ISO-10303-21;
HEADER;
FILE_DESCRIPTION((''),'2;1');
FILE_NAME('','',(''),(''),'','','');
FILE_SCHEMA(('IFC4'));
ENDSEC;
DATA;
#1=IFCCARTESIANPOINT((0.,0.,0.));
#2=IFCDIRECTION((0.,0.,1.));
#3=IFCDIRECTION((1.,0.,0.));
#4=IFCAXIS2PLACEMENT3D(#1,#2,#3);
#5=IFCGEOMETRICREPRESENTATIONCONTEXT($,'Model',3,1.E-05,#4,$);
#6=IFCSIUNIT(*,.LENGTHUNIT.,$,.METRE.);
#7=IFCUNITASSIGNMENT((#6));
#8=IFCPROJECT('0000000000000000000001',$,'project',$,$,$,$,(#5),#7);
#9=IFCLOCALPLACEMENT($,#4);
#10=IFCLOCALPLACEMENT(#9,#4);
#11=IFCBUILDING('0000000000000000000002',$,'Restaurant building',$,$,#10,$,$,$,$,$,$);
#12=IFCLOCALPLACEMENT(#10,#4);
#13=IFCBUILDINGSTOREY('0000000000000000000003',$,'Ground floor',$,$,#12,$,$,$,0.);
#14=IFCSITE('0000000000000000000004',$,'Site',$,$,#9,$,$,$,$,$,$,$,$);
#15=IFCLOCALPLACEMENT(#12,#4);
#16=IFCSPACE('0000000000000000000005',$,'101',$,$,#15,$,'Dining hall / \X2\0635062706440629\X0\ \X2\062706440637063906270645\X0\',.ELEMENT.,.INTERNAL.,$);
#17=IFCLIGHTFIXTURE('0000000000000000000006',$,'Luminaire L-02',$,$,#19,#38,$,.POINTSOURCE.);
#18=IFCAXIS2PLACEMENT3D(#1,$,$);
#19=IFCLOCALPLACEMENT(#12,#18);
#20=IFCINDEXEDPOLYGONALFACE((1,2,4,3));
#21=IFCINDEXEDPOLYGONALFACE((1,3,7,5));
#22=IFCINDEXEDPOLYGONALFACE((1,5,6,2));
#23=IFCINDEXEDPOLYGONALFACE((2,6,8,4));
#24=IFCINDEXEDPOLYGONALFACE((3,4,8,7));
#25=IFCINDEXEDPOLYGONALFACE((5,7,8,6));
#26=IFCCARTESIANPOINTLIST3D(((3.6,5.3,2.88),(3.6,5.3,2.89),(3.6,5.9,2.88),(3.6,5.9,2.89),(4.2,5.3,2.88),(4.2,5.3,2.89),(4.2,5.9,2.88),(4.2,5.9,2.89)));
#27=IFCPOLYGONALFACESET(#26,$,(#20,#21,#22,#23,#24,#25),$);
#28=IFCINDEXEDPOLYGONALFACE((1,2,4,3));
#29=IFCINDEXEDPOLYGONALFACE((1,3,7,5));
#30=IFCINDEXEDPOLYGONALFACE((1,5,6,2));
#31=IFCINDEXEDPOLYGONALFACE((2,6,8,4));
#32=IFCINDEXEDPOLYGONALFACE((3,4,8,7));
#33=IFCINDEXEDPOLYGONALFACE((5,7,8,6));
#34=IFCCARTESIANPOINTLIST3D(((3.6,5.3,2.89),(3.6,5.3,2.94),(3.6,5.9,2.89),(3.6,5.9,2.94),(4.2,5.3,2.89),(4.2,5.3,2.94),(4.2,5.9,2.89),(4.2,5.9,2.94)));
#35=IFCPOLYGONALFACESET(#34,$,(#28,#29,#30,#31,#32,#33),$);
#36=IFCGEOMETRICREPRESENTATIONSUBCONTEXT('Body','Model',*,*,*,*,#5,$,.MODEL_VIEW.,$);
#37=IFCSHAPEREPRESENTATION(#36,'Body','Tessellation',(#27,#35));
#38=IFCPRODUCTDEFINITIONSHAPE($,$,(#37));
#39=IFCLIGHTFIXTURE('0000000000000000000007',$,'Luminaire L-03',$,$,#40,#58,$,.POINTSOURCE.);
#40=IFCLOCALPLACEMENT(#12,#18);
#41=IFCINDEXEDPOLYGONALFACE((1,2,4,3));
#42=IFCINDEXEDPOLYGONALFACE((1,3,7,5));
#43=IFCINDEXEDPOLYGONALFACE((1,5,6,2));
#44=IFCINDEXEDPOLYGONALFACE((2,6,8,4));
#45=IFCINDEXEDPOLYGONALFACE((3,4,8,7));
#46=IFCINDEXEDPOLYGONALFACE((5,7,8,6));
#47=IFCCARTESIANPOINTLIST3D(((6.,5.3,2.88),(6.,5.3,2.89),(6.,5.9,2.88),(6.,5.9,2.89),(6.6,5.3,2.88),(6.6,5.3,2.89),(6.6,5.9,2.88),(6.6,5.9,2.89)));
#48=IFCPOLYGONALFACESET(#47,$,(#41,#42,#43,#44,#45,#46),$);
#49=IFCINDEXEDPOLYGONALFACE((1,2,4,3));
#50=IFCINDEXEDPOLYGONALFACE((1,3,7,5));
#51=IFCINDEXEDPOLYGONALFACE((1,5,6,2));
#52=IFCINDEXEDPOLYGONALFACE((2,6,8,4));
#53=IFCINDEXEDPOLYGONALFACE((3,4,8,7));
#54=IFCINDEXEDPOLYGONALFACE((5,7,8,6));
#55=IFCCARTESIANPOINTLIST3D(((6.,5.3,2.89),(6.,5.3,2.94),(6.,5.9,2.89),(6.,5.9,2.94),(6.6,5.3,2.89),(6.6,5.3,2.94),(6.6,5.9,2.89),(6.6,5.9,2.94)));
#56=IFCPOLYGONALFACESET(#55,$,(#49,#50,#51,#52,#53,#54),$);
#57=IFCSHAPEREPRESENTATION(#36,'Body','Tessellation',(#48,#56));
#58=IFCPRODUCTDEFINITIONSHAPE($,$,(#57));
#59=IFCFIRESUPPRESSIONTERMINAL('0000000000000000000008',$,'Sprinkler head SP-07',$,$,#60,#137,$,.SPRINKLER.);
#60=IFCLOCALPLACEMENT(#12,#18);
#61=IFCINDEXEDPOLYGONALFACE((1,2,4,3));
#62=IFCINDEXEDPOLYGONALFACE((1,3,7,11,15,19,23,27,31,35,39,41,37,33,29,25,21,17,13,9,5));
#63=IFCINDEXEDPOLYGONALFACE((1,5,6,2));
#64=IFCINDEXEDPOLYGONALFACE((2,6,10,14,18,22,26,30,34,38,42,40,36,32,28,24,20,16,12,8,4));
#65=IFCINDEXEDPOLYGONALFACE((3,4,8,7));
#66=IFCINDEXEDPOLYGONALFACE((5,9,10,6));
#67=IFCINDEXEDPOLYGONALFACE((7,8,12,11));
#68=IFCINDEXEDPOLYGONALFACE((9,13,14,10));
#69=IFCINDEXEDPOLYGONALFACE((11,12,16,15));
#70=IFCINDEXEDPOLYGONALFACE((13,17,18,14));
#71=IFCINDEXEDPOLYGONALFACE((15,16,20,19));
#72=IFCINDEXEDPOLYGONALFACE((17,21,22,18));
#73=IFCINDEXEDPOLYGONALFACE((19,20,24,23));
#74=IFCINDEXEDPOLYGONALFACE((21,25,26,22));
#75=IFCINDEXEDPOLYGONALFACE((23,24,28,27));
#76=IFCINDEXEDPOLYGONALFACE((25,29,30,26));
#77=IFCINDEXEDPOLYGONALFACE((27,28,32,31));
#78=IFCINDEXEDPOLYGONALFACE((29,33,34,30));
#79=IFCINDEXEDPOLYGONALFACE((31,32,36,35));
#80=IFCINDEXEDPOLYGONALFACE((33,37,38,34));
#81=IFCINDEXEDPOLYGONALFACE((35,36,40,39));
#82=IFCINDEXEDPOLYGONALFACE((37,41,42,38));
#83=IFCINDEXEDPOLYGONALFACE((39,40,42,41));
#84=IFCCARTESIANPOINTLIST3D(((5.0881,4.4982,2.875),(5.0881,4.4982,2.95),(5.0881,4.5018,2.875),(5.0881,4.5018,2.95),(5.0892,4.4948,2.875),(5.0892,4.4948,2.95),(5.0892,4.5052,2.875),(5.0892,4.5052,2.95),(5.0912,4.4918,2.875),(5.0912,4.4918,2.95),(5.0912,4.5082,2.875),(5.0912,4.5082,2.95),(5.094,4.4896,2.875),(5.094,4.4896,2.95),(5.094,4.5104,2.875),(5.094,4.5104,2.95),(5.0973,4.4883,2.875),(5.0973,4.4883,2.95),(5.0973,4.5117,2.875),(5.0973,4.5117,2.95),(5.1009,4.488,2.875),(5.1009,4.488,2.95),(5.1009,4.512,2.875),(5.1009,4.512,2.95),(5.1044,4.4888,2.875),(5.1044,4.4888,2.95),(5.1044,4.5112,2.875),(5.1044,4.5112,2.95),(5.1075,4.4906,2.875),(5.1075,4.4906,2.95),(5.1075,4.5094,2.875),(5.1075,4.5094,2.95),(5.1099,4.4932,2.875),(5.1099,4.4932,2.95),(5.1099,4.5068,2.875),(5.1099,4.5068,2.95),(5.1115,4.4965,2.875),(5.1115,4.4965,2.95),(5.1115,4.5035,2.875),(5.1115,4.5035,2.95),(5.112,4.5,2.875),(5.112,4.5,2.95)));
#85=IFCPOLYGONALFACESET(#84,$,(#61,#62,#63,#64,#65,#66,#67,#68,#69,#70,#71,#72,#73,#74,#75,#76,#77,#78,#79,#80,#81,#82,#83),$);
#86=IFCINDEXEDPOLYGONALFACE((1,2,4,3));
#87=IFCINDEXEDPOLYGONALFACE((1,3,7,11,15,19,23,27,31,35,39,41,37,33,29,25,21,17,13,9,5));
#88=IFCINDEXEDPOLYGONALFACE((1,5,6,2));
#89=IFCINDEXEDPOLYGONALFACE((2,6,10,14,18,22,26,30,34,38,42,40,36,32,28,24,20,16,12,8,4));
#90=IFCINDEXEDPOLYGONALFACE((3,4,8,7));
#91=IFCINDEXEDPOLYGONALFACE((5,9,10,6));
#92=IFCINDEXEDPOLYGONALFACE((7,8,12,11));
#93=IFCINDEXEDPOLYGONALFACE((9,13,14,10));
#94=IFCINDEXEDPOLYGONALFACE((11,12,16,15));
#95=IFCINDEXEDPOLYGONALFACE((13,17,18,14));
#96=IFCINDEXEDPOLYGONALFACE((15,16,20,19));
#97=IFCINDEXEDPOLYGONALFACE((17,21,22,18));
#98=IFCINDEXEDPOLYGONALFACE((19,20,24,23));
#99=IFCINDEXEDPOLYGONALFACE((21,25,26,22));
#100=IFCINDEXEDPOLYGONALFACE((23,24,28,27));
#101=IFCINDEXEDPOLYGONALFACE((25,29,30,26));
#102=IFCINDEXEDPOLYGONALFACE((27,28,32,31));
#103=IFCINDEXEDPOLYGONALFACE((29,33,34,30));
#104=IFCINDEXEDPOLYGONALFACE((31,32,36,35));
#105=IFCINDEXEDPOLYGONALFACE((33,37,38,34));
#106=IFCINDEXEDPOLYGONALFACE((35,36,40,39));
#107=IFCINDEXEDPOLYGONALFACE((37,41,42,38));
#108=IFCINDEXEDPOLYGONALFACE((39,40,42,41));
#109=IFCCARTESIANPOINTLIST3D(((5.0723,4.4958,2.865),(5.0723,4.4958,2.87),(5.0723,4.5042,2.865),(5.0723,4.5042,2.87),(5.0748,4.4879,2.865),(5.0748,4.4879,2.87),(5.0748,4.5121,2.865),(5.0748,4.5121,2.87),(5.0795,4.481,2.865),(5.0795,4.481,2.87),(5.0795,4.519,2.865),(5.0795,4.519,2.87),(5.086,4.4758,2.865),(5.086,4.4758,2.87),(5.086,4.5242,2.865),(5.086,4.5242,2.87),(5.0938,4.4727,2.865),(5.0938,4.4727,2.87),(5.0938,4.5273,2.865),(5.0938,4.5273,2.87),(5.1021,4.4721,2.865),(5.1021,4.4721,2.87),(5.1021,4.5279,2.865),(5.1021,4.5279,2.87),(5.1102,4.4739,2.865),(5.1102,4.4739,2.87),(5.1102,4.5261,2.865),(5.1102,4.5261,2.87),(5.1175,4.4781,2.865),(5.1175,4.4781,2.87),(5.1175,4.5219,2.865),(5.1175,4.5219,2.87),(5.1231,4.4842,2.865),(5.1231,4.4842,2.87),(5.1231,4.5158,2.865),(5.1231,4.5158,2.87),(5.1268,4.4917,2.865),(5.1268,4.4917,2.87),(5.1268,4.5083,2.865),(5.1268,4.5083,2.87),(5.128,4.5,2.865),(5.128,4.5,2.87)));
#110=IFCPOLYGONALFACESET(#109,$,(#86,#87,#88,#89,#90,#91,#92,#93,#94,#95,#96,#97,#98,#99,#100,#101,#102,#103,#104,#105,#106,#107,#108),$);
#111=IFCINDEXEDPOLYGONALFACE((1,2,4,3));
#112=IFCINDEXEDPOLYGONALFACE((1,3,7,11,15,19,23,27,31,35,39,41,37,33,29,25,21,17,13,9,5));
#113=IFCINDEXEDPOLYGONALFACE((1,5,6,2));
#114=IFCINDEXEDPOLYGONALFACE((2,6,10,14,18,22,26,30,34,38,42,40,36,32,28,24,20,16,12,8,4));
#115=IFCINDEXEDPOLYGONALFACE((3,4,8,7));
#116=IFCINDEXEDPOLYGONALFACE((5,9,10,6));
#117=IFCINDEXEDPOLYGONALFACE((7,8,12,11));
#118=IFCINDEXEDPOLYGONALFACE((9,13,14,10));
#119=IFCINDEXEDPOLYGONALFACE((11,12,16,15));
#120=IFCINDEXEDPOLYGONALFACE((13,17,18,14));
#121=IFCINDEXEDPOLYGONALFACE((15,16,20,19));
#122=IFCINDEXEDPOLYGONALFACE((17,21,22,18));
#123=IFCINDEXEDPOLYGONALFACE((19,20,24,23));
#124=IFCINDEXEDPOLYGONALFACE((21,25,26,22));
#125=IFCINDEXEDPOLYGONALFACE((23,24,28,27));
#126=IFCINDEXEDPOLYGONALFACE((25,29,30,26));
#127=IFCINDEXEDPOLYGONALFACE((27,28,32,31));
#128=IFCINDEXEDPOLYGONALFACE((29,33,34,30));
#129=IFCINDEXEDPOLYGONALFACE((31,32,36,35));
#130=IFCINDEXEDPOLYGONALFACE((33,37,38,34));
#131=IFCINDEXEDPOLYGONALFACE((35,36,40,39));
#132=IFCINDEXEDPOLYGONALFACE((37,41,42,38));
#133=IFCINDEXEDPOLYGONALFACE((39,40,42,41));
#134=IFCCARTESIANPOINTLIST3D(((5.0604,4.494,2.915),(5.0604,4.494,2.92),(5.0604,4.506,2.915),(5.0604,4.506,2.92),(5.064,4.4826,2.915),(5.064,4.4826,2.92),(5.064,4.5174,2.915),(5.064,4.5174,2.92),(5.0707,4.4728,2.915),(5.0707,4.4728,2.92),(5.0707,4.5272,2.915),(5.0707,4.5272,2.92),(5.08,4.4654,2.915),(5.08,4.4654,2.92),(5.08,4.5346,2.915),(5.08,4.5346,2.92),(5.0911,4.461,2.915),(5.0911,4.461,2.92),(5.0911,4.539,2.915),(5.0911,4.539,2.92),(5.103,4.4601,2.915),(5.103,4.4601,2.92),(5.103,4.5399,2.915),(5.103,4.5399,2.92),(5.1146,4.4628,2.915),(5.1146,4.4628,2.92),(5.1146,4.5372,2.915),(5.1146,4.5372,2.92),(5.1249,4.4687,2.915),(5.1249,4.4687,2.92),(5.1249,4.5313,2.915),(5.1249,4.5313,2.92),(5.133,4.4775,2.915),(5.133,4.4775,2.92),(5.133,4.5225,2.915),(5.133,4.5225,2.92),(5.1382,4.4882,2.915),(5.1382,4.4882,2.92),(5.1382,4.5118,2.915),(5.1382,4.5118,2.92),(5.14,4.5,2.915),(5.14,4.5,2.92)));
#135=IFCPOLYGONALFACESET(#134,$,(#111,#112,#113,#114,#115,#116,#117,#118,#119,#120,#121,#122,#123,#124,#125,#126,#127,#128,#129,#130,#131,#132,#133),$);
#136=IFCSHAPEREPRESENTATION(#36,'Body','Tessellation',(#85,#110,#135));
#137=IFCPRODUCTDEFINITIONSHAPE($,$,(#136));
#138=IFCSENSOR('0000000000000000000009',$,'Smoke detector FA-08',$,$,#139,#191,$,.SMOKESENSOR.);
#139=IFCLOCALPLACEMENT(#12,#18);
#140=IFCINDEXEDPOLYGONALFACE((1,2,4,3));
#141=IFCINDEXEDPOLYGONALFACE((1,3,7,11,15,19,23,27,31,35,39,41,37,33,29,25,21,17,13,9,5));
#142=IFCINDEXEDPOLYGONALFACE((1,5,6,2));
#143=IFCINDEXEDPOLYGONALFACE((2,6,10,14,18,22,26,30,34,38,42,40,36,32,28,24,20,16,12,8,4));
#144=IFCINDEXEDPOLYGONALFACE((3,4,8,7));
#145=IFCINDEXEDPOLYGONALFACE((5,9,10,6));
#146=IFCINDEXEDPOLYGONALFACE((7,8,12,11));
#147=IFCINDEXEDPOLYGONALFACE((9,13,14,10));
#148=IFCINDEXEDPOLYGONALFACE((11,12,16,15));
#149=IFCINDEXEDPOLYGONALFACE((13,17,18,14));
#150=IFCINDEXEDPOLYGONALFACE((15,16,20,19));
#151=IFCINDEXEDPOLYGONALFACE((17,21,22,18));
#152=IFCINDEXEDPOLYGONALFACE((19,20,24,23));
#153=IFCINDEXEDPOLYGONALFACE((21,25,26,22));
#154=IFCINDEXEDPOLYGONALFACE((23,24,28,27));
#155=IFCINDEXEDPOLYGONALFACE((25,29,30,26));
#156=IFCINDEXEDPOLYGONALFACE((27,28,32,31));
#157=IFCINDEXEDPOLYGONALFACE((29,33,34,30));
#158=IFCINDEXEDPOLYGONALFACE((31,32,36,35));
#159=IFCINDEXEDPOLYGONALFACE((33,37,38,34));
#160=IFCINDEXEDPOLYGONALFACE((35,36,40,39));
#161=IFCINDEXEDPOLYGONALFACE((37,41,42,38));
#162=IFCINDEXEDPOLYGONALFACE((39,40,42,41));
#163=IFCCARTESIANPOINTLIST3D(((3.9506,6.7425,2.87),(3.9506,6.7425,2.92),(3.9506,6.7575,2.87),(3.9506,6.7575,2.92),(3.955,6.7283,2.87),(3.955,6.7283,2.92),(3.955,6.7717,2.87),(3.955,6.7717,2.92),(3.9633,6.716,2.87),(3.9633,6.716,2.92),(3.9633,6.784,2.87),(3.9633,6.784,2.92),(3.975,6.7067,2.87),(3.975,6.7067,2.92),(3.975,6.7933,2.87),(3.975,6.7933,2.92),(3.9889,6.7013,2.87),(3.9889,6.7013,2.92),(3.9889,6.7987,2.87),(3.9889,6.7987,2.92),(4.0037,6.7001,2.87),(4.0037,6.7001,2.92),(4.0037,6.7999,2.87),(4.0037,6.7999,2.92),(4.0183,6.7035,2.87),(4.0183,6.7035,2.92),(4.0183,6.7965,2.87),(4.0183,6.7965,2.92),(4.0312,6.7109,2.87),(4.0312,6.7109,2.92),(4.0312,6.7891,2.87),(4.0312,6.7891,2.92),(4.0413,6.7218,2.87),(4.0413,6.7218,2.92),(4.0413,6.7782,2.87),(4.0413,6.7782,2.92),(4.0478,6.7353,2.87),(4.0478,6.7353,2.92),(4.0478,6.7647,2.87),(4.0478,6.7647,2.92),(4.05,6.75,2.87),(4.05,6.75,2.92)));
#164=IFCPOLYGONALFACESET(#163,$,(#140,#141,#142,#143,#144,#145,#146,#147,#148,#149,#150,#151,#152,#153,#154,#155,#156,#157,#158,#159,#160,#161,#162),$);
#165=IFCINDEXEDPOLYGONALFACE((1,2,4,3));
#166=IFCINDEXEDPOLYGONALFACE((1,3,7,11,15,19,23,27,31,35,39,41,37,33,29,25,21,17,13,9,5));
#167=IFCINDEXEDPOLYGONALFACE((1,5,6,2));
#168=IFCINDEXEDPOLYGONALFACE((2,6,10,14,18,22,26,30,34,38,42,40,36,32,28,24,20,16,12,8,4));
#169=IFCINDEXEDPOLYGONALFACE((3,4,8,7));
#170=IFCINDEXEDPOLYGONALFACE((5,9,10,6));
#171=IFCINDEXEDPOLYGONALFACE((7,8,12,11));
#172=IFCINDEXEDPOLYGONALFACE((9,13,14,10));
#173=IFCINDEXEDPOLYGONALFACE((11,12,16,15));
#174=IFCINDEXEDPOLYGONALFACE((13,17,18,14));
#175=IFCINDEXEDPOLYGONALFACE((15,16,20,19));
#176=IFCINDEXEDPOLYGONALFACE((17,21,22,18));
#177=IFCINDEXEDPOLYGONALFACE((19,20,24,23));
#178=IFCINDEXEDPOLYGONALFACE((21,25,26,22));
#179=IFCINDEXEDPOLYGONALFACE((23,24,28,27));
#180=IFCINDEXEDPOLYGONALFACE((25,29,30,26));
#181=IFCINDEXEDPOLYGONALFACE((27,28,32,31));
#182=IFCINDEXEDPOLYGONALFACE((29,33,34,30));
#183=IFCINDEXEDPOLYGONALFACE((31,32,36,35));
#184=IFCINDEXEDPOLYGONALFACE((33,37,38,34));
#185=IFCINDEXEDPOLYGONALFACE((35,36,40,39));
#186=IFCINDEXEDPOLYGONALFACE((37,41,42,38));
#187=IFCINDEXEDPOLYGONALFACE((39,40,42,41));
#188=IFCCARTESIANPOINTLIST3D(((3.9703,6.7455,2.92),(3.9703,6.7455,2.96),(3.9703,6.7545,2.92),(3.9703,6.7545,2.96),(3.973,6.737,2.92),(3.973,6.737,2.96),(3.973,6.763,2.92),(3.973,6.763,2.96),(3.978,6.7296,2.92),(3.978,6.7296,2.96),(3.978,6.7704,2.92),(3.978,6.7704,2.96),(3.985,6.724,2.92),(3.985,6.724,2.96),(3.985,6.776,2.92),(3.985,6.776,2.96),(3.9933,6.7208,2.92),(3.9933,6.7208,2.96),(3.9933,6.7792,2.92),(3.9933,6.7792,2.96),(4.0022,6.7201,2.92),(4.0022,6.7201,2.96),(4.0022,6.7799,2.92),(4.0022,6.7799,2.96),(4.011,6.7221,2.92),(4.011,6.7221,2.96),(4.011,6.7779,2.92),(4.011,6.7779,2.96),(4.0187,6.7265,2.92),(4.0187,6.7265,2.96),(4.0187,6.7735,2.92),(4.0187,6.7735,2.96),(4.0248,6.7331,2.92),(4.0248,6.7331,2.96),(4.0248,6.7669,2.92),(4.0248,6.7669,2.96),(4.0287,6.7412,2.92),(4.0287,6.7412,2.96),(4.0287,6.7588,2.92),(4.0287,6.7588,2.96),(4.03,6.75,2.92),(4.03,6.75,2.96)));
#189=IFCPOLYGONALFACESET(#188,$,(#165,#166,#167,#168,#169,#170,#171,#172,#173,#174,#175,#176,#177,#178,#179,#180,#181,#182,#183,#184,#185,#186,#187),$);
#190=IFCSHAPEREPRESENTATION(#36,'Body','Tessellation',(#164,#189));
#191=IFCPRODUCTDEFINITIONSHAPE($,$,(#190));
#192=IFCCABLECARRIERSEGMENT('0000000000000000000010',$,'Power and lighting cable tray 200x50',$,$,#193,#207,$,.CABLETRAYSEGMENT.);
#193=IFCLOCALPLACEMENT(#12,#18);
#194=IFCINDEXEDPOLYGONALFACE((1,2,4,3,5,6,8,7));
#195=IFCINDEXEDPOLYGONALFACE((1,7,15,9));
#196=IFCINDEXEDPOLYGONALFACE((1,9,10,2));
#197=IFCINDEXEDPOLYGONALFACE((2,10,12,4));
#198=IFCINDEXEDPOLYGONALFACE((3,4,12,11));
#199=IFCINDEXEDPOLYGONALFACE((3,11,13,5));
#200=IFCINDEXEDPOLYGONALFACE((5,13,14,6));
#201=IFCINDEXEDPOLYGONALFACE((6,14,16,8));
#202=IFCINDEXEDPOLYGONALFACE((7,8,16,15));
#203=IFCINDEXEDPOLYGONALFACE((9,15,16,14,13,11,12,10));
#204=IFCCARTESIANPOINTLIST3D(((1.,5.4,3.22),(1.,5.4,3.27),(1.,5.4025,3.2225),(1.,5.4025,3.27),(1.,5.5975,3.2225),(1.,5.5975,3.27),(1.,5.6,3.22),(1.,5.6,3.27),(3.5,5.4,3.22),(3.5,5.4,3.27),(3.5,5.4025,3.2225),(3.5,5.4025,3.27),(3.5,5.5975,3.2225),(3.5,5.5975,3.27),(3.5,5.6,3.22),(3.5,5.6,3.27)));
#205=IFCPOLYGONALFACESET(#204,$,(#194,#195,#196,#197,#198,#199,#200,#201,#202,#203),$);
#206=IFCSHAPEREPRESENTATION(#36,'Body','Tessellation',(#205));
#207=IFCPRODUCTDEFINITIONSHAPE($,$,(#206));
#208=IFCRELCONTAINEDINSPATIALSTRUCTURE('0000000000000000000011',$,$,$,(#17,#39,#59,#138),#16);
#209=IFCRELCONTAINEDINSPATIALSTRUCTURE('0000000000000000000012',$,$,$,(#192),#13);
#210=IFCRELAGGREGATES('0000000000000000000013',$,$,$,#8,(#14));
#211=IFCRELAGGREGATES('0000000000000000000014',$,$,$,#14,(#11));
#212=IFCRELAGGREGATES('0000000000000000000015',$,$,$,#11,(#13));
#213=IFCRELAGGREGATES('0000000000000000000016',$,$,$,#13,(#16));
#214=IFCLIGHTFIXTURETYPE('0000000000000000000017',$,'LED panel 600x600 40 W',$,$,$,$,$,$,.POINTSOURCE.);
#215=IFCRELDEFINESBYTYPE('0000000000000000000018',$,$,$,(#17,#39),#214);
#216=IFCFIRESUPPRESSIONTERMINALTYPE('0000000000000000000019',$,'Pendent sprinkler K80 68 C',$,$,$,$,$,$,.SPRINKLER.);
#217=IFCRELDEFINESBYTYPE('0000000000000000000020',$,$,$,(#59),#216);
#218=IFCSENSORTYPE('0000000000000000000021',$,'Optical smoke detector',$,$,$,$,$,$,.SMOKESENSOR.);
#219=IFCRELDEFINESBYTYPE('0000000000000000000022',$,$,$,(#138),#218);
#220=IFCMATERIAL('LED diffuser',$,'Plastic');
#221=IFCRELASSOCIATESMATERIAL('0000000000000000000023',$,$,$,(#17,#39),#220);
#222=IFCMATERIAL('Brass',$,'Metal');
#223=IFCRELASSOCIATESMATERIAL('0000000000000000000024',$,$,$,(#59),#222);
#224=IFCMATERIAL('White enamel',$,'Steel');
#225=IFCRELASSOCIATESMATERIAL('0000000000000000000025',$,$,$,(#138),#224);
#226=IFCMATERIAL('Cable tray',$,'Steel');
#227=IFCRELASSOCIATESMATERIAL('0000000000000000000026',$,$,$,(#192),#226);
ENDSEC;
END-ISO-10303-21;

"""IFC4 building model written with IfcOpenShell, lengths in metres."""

from ifc_helpers import new_model, si_unit, frame, origin, origin_with_axes, origin_2d, place, context, subcontext, project, spatial, polyline, rectangle, circle, outline, extrude, source, transform, mapped, material, type_object, type_shapes, element, save


model = new_model("IFC4")

# Units and contexts
model_context = context("Model", 3, precision=1e-05, world=origin_with_axes())
body_context = subcontext(model_context, "Body", "Model", "MODEL_VIEW")
ifc_project = project(units=[si_unit("LENGTHUNIT", "METRE")], contexts=[model_context])

# Site, building, storey, space
site_placement = place(None, origin_with_axes())
site = spatial("IfcSite", under=ifc_project, at=site_placement, Name="Site")
building_placement = place(site_placement, origin_with_axes())
building = spatial("IfcBuilding", under=site, at=building_placement, Name="Restaurant building")
storey_placement = place(building_placement, origin_with_axes())
storey = spatial("IfcBuildingStorey", under=building, at=storey_placement, Name="Ground floor", Elevation=0.0)
space_placement = place(storey_placement, origin_with_axes())
space = spatial("IfcSpace", under=storey, at=space_placement, Name="101", LongName="Dining hall / صالة الطعام", CompositionType="ELEMENT", PredefinedType="INTERNAL")

# Light fixtures
ifc_material_1 = material(Name="LED diffuser", Category="Plastic")
light_fixture_type = type_object("IfcLightFixtureType", Name="LED panel 600x600 40 W", PredefinedType="POINTSOURCE")
shared_shape_1 = source(origin(), body_context, "Body", "SweptSolid", [
    extrude(rectangle(XDim=0.6, YDim=0.6, at=origin_2d()), frame((0.0, 0.0, -0.06)), (0.0, 0.0, 1.0), 0.01),
    extrude(rectangle(XDim=0.6, YDim=0.6, at=origin_2d()), frame((0.0, 0.0, -0.05)), (0.0, 0.0, 1.0), 0.05),
])
type_shapes(light_fixture_type, [shared_shape_1])
for number, where, name in (
    (1, (3.9, 5.6, 2.94), "Luminaire L-02"),
    (2, (6.3, 5.6, 2.94), "Luminaire L-03"),
):
    element("IfcLightFixture", number, at=place(storey_placement, frame(where)), inside=space, type_object=light_fixture_type, material=ifc_material_1, Name=name, PredefinedType="POINTSOURCE", context=body_context, shape_type="MappedRepresentation", body=[
        mapped(shared_shape_1, transform((0.0, 0.0, 0.0))),
    ])

# Fire suppression terminal
ifc_material_2 = material(Name="Brass", Category="Metal")
fire_suppression_terminal_type = type_object("IfcFireSuppressionTerminalType", Name="Pendent sprinkler K80 68 C", PredefinedType="SPRINKLER")
shared_shape_2 = source(origin(), body_context, "Body", "SweptSolid", [
    extrude(circle(Radius=0.012, at=origin_2d()), frame((0.0, 0.0, -0.075)), (0.0, 0.0, 1.0), 0.075),
    extrude(circle(Radius=0.028, at=origin_2d()), frame((0.0, 0.0, -0.085)), (0.0, 0.0, 1.0), 0.005),
    extrude(circle(Radius=0.04, at=origin_2d()), frame((0.0, 0.0, -0.035)), (0.0, 0.0, 1.0), 0.005),
])
type_shapes(fire_suppression_terminal_type, [shared_shape_2])
fire_suppression_terminal_placement = place(storey_placement, frame((5.1, 4.5, 2.95)))
element("IfcFireSuppressionTerminal", 3, at=fire_suppression_terminal_placement, inside=space, type_object=fire_suppression_terminal_type, material=ifc_material_2, Name="Sprinkler head SP-07", PredefinedType="SPRINKLER", context=body_context, shape_type="MappedRepresentation", body=[
    mapped(shared_shape_2, transform((0.0, 0.0, 0.0))),
])

# Sensor
ifc_material_3 = material(Name="White enamel", Category="Steel")
sensor_type = type_object("IfcSensorType", Name="Optical smoke detector", PredefinedType="SMOKESENSOR")
shared_shape_3 = source(origin(), body_context, "Body", "SweptSolid", [
    extrude(circle(Radius=0.05, at=origin_2d()), frame((0.0, 0.0, -0.09)), (0.0, 0.0, 1.0), 0.05),
    extrude(circle(Radius=0.03, at=origin_2d()), frame((0.0, 0.0, -0.04)), (0.0, 0.0, 1.0), 0.04),
])
type_shapes(sensor_type, [shared_shape_3])
sensor_placement = place(storey_placement, frame((4.0, 6.75, 2.96)))
element("IfcSensor", 4, at=sensor_placement, inside=space, type_object=sensor_type, material=ifc_material_3, Name="Smoke detector FA-08", PredefinedType="SMOKESENSOR", context=body_context, shape_type="MappedRepresentation", body=[
    mapped(shared_shape_3, transform((0.0, 0.0, 0.0))),
])

# Cable carrier segment
ifc_material_4 = material(Name="Cable tray", Category="Steel")
cable_carrier_segment_1_placement = place(storey_placement, frame((3.5, 5.5, 3.245)))
element("IfcCableCarrierSegment", 5, at=cable_carrier_segment_1_placement, inside=storey, material=ifc_material_4, Name="Power and lighting cable tray 200x50", PredefinedType="CABLETRAYSEGMENT", context=body_context, shape_type="SweptSolid", body=[
    extrude(outline(polyline([(-0.1, -0.025), (0.1, -0.025), (0.1, 0.025), (0.0975, 0.025), (0.0975, -0.0225), (-0.0975, -0.0225), (-0.0975, 0.025), (-0.1, 0.025), (-0.1, -0.025)])), frame((0.0, 0.0, 0.0), z_axis=(-1.0, 0.0, 0.0), x_axis=(0.0, -1.0, 0.0)), (0.0, 0.0, 1.0), 2.5),
])

save(model, "model.ifc")
